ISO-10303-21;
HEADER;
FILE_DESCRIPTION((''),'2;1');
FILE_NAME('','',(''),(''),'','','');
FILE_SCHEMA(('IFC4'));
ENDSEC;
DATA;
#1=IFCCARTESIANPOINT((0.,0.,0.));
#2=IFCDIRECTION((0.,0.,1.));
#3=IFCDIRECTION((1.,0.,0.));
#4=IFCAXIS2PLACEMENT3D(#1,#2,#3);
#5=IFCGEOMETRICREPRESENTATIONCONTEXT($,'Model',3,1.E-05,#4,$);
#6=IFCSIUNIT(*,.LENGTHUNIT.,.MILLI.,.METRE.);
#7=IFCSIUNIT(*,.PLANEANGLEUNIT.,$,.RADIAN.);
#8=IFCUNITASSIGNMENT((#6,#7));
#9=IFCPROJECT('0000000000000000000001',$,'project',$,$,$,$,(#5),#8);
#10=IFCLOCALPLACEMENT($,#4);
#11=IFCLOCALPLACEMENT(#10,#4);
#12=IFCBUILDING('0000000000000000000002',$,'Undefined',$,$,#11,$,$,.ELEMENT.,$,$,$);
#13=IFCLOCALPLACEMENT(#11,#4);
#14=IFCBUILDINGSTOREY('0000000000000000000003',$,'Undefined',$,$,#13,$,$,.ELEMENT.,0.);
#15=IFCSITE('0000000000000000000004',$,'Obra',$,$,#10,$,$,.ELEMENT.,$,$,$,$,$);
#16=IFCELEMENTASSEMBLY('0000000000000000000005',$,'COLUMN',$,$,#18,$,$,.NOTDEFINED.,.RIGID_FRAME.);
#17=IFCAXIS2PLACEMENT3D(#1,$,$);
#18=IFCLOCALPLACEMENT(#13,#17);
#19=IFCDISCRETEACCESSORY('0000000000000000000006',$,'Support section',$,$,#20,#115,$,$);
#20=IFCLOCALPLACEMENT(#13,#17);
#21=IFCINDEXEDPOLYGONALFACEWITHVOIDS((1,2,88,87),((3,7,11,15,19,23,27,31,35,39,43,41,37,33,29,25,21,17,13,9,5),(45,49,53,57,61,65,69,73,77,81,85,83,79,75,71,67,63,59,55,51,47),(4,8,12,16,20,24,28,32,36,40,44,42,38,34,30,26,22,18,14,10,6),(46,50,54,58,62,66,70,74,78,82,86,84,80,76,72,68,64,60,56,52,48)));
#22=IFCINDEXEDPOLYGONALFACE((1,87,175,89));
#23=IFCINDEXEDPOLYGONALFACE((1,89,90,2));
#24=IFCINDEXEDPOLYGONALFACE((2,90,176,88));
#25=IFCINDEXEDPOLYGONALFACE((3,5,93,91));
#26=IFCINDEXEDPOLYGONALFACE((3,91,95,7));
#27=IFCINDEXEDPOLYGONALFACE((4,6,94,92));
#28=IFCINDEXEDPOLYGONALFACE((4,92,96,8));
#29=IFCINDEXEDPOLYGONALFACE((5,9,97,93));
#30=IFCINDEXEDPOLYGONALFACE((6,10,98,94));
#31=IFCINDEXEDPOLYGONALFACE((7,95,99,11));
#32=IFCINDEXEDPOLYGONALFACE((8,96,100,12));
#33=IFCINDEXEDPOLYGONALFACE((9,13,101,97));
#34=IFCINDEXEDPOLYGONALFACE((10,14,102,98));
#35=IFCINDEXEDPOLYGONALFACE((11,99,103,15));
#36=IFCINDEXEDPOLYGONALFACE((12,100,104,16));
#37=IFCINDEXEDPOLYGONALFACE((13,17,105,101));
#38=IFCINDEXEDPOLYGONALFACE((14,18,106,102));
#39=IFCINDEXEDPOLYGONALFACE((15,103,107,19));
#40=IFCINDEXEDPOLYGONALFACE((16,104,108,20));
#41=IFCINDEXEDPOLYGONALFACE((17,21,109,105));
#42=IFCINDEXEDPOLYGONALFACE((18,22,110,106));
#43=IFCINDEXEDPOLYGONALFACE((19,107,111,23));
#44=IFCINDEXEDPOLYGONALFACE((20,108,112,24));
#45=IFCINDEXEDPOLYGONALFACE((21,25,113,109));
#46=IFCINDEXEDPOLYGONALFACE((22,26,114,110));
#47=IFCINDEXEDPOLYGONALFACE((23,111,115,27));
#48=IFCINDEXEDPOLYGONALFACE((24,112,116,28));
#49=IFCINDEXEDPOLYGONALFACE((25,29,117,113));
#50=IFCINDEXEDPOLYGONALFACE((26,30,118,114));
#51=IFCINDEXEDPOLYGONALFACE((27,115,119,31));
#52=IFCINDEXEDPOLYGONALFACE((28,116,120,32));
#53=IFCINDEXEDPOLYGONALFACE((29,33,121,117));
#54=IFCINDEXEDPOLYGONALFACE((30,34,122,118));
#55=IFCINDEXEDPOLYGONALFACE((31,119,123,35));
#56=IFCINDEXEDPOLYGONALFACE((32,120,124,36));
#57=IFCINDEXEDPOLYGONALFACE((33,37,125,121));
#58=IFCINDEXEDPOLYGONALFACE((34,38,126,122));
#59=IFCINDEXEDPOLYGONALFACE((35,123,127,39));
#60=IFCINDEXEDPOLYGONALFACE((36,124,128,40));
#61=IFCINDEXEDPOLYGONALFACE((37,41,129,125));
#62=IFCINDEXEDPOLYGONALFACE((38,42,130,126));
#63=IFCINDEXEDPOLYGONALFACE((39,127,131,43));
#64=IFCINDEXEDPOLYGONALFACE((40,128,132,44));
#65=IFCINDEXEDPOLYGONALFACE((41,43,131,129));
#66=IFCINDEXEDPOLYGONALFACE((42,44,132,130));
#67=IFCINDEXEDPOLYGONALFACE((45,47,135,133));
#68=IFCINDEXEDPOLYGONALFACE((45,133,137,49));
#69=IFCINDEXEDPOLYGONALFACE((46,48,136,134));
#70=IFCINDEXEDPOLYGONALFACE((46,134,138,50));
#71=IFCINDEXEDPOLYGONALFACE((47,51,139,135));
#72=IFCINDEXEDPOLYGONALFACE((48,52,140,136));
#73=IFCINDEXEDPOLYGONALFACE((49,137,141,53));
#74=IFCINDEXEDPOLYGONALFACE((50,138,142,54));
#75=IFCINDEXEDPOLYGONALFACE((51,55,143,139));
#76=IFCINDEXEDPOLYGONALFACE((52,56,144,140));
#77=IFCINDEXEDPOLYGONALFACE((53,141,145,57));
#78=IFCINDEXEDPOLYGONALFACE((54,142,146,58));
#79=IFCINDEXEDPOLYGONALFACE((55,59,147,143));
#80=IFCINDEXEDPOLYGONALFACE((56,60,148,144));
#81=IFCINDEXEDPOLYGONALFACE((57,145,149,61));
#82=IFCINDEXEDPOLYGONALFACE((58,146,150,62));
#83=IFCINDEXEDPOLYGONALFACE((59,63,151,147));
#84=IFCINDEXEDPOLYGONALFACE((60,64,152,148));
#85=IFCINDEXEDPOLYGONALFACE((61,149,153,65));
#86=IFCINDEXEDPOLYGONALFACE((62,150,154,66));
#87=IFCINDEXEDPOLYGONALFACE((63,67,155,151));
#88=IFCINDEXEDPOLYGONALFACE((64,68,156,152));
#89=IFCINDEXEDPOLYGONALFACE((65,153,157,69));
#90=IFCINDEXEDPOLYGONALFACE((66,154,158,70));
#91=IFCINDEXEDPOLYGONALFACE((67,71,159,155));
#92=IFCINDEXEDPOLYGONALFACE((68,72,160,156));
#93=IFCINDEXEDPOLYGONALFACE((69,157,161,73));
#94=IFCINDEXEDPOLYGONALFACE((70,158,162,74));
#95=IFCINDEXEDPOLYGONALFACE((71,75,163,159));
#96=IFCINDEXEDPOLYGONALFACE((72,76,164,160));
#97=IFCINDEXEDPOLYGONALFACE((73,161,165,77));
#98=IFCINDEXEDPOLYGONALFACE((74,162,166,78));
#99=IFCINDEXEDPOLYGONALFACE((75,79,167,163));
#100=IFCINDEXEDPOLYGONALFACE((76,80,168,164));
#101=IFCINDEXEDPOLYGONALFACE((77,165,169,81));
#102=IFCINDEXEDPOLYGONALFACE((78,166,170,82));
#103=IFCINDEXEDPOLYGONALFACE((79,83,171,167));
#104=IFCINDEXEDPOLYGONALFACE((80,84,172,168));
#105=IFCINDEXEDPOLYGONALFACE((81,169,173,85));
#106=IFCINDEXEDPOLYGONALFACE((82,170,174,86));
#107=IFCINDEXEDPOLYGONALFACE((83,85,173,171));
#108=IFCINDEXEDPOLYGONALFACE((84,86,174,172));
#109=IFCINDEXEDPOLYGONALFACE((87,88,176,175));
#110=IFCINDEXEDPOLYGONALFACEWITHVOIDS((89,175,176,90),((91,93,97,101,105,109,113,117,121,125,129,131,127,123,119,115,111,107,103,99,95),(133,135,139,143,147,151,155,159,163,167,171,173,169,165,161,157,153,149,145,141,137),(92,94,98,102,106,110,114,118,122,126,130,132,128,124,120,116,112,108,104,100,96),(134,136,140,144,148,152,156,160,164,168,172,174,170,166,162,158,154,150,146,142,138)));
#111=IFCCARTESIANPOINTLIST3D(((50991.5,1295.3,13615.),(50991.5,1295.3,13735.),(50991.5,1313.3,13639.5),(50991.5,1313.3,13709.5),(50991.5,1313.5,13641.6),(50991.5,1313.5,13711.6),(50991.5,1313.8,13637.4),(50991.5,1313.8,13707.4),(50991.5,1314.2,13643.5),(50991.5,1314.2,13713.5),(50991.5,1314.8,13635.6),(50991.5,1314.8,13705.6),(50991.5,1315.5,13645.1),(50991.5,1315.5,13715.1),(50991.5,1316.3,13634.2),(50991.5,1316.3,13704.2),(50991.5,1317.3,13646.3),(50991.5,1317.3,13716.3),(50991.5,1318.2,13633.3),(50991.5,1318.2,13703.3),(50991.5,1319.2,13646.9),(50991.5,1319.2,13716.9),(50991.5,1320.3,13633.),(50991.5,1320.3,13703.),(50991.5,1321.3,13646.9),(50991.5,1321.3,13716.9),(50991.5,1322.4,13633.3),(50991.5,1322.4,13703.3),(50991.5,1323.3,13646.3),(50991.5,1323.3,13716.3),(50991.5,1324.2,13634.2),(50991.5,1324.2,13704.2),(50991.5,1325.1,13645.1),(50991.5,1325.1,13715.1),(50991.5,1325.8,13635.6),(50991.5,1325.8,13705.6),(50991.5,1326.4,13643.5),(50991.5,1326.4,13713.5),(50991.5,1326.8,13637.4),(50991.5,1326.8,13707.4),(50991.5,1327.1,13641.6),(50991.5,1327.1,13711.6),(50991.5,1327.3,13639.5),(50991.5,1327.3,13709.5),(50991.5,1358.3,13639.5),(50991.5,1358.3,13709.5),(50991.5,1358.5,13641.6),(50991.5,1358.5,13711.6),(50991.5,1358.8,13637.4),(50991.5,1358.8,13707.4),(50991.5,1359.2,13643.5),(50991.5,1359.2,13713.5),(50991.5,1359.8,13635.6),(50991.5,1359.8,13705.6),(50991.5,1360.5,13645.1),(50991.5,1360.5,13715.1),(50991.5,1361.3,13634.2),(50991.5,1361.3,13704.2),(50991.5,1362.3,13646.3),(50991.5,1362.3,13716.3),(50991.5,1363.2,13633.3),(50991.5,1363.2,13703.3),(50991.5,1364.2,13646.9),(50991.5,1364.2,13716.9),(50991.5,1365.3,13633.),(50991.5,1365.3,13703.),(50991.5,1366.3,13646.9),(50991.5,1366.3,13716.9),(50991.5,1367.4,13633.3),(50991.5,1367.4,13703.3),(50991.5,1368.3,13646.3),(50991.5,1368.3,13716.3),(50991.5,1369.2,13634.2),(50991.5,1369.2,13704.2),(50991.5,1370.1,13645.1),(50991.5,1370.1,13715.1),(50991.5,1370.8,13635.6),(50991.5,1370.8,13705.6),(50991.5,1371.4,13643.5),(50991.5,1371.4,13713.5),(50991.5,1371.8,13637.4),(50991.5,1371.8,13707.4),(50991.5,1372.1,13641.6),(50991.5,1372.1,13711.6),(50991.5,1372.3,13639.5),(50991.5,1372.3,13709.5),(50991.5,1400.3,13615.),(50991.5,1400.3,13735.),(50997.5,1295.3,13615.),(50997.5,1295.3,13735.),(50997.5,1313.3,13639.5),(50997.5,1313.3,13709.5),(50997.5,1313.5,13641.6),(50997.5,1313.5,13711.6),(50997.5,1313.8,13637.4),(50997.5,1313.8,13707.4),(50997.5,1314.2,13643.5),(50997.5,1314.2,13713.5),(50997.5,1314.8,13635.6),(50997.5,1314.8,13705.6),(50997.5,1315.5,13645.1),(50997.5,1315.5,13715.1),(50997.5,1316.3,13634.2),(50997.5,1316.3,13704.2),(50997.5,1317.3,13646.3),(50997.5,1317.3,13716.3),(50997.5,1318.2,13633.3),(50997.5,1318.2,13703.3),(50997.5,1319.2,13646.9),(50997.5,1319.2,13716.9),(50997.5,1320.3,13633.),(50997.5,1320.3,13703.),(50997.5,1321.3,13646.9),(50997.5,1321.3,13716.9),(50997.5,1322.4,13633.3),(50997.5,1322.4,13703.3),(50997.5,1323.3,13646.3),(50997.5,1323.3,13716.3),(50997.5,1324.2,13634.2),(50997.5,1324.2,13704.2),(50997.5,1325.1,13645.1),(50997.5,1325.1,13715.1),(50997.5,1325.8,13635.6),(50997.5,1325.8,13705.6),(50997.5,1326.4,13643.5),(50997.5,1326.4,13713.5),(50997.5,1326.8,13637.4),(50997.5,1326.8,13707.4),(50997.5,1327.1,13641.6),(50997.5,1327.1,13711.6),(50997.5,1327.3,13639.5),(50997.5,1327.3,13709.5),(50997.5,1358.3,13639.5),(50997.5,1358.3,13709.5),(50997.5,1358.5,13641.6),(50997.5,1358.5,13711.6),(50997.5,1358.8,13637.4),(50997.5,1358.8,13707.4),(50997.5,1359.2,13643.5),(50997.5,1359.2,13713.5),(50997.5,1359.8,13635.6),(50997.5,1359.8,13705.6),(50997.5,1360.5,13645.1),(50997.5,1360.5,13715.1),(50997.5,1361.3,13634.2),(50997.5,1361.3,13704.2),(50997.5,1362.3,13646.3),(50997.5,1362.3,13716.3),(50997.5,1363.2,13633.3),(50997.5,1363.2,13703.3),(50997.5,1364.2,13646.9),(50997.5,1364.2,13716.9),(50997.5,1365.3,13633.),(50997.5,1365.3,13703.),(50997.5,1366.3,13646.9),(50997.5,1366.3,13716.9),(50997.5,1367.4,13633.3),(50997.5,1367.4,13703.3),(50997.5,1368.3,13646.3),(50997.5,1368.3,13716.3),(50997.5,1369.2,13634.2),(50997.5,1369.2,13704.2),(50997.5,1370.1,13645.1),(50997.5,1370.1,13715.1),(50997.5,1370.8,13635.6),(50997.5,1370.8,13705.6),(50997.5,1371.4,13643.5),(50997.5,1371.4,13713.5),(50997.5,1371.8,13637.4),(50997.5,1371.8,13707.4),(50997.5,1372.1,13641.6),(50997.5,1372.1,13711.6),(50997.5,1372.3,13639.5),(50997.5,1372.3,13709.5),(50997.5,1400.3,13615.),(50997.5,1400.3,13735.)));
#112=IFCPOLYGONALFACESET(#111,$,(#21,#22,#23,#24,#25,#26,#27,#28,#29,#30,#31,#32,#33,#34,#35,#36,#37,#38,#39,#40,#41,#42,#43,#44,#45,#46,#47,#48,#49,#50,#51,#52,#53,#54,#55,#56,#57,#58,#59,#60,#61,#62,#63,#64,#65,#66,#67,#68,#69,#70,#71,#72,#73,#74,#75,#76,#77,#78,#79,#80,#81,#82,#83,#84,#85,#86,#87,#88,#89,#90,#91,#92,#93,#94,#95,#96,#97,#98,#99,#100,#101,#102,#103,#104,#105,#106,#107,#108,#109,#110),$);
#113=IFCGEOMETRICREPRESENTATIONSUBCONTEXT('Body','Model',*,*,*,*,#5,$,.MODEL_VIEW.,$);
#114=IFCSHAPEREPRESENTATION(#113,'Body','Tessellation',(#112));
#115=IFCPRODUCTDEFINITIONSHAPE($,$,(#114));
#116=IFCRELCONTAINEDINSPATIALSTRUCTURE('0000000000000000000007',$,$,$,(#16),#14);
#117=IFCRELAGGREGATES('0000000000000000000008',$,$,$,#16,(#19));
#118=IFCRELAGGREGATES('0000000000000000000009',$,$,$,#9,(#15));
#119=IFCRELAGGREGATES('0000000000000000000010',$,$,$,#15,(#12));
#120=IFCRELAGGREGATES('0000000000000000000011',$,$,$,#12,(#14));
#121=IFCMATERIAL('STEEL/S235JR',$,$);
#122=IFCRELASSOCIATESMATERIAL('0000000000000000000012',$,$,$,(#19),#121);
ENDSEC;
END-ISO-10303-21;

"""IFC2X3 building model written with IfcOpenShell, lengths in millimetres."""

from ifc_helpers import new_model, si_unit, frame, origin_with_axes, origin_2d_with_axis, place, context, subcontext, project, spatial, rectangle, circle, extrude, source, transform, mapped, material, element, aggregate, save


model = new_model("IFC2X3")

# Units and contexts
model_context = context("Model", 3, precision=1e-05, world=origin_with_axes())
body_context = subcontext(model_context, "Body", "Model", "MODEL_VIEW")
ifc_project = project(units=[si_unit("LENGTHUNIT", "METRE", prefix="MILLI"), si_unit("PLANEANGLEUNIT", "RADIAN")], contexts=[model_context])

# Site, building, storey
site_placement = place(None, origin_with_axes())
site = spatial("IfcSite", under=ifc_project, at=site_placement, Name="Obra", CompositionType="ELEMENT")
building_placement = place(site_placement, origin_with_axes())
building = spatial("IfcBuilding", under=site, at=building_placement, Name="Undefined", CompositionType="ELEMENT")
storey_placement = place(building_placement, origin_with_axes())
storey = spatial("IfcBuildingStorey", under=building, at=storey_placement, Name="Undefined", CompositionType="ELEMENT", Elevation=0.0)

# Shared definitions
ifc_material_1 = material(Name="STEEL/S235JR")

# Element assembly
assembly_1_placement = place(storey_placement, origin_with_axes())
assembly_1 = element("IfcElementAssembly", 1, at=assembly_1_placement, inside=storey, Name="COLUMN", AssemblyPlace="NOTDEFINED", PredefinedType="RIGID_FRAME")
shared_shape_1 = source(origin_with_axes(), body_context, "Body", "SweptSolid", [
    extrude(circle(Radius=7.0, at=origin_2d_with_axis()), frame((0.0, -8.6, 0.0), z_axis=(0.0, 1.0, 0.0), x_axis=(1.0, 0.0, 0.0)), (0.0, 0.0, 1.0), 6.2),
])

# Discrete accessory, opening
discrete_accessory_1_placement = place(assembly_1_placement, frame((50994.5, 1347.8, 13615.0), z_axis=(0.0, 0.0, 1.0), x_axis=(0.0, 1.0, 0.0)))
discrete_accessory_1 = element("IfcDiscreteAccessory", 2, at=discrete_accessory_1_placement, material=ifc_material_1, Name="Support section", context=body_context, shape_type="SweptSolid", body=[
    extrude(rectangle(XDim=6.0, YDim=105.0, at=origin_2d_with_axis()), frame((0.0, 0.0, 120.0), z_axis=(0.0, 0.0, -1.0), x_axis=(0.0, 1.0, 0.0)), (0.0, 0.0, 1.0), 120.0),
])
opening_1_placement = place(assembly_1_placement, frame((51000.0, 1390.3, 13755.0), z_axis=(0.0, -1.0, 0.0), x_axis=(0.0, 0.0, -1.0)))
element("IfcOpeningElement", 3, at=opening_1_placement, cuts=discrete_accessory_1, ObjectType="Opening", context=body_context, shape_type="MappedRepresentation", body=[
    mapped(shared_shape_1, transform((45.0, 0.0, 25.0))),
    mapped(shared_shape_1, transform((45.0, 0.0, 70.0))),
    mapped(shared_shape_1, transform((115.0, 0.0, 25.0))),
    mapped(shared_shape_1, transform((115.0, 0.0, 70.0))),
])
aggregate(assembly_1, [discrete_accessory_1])

save(model, "model.ifc")
